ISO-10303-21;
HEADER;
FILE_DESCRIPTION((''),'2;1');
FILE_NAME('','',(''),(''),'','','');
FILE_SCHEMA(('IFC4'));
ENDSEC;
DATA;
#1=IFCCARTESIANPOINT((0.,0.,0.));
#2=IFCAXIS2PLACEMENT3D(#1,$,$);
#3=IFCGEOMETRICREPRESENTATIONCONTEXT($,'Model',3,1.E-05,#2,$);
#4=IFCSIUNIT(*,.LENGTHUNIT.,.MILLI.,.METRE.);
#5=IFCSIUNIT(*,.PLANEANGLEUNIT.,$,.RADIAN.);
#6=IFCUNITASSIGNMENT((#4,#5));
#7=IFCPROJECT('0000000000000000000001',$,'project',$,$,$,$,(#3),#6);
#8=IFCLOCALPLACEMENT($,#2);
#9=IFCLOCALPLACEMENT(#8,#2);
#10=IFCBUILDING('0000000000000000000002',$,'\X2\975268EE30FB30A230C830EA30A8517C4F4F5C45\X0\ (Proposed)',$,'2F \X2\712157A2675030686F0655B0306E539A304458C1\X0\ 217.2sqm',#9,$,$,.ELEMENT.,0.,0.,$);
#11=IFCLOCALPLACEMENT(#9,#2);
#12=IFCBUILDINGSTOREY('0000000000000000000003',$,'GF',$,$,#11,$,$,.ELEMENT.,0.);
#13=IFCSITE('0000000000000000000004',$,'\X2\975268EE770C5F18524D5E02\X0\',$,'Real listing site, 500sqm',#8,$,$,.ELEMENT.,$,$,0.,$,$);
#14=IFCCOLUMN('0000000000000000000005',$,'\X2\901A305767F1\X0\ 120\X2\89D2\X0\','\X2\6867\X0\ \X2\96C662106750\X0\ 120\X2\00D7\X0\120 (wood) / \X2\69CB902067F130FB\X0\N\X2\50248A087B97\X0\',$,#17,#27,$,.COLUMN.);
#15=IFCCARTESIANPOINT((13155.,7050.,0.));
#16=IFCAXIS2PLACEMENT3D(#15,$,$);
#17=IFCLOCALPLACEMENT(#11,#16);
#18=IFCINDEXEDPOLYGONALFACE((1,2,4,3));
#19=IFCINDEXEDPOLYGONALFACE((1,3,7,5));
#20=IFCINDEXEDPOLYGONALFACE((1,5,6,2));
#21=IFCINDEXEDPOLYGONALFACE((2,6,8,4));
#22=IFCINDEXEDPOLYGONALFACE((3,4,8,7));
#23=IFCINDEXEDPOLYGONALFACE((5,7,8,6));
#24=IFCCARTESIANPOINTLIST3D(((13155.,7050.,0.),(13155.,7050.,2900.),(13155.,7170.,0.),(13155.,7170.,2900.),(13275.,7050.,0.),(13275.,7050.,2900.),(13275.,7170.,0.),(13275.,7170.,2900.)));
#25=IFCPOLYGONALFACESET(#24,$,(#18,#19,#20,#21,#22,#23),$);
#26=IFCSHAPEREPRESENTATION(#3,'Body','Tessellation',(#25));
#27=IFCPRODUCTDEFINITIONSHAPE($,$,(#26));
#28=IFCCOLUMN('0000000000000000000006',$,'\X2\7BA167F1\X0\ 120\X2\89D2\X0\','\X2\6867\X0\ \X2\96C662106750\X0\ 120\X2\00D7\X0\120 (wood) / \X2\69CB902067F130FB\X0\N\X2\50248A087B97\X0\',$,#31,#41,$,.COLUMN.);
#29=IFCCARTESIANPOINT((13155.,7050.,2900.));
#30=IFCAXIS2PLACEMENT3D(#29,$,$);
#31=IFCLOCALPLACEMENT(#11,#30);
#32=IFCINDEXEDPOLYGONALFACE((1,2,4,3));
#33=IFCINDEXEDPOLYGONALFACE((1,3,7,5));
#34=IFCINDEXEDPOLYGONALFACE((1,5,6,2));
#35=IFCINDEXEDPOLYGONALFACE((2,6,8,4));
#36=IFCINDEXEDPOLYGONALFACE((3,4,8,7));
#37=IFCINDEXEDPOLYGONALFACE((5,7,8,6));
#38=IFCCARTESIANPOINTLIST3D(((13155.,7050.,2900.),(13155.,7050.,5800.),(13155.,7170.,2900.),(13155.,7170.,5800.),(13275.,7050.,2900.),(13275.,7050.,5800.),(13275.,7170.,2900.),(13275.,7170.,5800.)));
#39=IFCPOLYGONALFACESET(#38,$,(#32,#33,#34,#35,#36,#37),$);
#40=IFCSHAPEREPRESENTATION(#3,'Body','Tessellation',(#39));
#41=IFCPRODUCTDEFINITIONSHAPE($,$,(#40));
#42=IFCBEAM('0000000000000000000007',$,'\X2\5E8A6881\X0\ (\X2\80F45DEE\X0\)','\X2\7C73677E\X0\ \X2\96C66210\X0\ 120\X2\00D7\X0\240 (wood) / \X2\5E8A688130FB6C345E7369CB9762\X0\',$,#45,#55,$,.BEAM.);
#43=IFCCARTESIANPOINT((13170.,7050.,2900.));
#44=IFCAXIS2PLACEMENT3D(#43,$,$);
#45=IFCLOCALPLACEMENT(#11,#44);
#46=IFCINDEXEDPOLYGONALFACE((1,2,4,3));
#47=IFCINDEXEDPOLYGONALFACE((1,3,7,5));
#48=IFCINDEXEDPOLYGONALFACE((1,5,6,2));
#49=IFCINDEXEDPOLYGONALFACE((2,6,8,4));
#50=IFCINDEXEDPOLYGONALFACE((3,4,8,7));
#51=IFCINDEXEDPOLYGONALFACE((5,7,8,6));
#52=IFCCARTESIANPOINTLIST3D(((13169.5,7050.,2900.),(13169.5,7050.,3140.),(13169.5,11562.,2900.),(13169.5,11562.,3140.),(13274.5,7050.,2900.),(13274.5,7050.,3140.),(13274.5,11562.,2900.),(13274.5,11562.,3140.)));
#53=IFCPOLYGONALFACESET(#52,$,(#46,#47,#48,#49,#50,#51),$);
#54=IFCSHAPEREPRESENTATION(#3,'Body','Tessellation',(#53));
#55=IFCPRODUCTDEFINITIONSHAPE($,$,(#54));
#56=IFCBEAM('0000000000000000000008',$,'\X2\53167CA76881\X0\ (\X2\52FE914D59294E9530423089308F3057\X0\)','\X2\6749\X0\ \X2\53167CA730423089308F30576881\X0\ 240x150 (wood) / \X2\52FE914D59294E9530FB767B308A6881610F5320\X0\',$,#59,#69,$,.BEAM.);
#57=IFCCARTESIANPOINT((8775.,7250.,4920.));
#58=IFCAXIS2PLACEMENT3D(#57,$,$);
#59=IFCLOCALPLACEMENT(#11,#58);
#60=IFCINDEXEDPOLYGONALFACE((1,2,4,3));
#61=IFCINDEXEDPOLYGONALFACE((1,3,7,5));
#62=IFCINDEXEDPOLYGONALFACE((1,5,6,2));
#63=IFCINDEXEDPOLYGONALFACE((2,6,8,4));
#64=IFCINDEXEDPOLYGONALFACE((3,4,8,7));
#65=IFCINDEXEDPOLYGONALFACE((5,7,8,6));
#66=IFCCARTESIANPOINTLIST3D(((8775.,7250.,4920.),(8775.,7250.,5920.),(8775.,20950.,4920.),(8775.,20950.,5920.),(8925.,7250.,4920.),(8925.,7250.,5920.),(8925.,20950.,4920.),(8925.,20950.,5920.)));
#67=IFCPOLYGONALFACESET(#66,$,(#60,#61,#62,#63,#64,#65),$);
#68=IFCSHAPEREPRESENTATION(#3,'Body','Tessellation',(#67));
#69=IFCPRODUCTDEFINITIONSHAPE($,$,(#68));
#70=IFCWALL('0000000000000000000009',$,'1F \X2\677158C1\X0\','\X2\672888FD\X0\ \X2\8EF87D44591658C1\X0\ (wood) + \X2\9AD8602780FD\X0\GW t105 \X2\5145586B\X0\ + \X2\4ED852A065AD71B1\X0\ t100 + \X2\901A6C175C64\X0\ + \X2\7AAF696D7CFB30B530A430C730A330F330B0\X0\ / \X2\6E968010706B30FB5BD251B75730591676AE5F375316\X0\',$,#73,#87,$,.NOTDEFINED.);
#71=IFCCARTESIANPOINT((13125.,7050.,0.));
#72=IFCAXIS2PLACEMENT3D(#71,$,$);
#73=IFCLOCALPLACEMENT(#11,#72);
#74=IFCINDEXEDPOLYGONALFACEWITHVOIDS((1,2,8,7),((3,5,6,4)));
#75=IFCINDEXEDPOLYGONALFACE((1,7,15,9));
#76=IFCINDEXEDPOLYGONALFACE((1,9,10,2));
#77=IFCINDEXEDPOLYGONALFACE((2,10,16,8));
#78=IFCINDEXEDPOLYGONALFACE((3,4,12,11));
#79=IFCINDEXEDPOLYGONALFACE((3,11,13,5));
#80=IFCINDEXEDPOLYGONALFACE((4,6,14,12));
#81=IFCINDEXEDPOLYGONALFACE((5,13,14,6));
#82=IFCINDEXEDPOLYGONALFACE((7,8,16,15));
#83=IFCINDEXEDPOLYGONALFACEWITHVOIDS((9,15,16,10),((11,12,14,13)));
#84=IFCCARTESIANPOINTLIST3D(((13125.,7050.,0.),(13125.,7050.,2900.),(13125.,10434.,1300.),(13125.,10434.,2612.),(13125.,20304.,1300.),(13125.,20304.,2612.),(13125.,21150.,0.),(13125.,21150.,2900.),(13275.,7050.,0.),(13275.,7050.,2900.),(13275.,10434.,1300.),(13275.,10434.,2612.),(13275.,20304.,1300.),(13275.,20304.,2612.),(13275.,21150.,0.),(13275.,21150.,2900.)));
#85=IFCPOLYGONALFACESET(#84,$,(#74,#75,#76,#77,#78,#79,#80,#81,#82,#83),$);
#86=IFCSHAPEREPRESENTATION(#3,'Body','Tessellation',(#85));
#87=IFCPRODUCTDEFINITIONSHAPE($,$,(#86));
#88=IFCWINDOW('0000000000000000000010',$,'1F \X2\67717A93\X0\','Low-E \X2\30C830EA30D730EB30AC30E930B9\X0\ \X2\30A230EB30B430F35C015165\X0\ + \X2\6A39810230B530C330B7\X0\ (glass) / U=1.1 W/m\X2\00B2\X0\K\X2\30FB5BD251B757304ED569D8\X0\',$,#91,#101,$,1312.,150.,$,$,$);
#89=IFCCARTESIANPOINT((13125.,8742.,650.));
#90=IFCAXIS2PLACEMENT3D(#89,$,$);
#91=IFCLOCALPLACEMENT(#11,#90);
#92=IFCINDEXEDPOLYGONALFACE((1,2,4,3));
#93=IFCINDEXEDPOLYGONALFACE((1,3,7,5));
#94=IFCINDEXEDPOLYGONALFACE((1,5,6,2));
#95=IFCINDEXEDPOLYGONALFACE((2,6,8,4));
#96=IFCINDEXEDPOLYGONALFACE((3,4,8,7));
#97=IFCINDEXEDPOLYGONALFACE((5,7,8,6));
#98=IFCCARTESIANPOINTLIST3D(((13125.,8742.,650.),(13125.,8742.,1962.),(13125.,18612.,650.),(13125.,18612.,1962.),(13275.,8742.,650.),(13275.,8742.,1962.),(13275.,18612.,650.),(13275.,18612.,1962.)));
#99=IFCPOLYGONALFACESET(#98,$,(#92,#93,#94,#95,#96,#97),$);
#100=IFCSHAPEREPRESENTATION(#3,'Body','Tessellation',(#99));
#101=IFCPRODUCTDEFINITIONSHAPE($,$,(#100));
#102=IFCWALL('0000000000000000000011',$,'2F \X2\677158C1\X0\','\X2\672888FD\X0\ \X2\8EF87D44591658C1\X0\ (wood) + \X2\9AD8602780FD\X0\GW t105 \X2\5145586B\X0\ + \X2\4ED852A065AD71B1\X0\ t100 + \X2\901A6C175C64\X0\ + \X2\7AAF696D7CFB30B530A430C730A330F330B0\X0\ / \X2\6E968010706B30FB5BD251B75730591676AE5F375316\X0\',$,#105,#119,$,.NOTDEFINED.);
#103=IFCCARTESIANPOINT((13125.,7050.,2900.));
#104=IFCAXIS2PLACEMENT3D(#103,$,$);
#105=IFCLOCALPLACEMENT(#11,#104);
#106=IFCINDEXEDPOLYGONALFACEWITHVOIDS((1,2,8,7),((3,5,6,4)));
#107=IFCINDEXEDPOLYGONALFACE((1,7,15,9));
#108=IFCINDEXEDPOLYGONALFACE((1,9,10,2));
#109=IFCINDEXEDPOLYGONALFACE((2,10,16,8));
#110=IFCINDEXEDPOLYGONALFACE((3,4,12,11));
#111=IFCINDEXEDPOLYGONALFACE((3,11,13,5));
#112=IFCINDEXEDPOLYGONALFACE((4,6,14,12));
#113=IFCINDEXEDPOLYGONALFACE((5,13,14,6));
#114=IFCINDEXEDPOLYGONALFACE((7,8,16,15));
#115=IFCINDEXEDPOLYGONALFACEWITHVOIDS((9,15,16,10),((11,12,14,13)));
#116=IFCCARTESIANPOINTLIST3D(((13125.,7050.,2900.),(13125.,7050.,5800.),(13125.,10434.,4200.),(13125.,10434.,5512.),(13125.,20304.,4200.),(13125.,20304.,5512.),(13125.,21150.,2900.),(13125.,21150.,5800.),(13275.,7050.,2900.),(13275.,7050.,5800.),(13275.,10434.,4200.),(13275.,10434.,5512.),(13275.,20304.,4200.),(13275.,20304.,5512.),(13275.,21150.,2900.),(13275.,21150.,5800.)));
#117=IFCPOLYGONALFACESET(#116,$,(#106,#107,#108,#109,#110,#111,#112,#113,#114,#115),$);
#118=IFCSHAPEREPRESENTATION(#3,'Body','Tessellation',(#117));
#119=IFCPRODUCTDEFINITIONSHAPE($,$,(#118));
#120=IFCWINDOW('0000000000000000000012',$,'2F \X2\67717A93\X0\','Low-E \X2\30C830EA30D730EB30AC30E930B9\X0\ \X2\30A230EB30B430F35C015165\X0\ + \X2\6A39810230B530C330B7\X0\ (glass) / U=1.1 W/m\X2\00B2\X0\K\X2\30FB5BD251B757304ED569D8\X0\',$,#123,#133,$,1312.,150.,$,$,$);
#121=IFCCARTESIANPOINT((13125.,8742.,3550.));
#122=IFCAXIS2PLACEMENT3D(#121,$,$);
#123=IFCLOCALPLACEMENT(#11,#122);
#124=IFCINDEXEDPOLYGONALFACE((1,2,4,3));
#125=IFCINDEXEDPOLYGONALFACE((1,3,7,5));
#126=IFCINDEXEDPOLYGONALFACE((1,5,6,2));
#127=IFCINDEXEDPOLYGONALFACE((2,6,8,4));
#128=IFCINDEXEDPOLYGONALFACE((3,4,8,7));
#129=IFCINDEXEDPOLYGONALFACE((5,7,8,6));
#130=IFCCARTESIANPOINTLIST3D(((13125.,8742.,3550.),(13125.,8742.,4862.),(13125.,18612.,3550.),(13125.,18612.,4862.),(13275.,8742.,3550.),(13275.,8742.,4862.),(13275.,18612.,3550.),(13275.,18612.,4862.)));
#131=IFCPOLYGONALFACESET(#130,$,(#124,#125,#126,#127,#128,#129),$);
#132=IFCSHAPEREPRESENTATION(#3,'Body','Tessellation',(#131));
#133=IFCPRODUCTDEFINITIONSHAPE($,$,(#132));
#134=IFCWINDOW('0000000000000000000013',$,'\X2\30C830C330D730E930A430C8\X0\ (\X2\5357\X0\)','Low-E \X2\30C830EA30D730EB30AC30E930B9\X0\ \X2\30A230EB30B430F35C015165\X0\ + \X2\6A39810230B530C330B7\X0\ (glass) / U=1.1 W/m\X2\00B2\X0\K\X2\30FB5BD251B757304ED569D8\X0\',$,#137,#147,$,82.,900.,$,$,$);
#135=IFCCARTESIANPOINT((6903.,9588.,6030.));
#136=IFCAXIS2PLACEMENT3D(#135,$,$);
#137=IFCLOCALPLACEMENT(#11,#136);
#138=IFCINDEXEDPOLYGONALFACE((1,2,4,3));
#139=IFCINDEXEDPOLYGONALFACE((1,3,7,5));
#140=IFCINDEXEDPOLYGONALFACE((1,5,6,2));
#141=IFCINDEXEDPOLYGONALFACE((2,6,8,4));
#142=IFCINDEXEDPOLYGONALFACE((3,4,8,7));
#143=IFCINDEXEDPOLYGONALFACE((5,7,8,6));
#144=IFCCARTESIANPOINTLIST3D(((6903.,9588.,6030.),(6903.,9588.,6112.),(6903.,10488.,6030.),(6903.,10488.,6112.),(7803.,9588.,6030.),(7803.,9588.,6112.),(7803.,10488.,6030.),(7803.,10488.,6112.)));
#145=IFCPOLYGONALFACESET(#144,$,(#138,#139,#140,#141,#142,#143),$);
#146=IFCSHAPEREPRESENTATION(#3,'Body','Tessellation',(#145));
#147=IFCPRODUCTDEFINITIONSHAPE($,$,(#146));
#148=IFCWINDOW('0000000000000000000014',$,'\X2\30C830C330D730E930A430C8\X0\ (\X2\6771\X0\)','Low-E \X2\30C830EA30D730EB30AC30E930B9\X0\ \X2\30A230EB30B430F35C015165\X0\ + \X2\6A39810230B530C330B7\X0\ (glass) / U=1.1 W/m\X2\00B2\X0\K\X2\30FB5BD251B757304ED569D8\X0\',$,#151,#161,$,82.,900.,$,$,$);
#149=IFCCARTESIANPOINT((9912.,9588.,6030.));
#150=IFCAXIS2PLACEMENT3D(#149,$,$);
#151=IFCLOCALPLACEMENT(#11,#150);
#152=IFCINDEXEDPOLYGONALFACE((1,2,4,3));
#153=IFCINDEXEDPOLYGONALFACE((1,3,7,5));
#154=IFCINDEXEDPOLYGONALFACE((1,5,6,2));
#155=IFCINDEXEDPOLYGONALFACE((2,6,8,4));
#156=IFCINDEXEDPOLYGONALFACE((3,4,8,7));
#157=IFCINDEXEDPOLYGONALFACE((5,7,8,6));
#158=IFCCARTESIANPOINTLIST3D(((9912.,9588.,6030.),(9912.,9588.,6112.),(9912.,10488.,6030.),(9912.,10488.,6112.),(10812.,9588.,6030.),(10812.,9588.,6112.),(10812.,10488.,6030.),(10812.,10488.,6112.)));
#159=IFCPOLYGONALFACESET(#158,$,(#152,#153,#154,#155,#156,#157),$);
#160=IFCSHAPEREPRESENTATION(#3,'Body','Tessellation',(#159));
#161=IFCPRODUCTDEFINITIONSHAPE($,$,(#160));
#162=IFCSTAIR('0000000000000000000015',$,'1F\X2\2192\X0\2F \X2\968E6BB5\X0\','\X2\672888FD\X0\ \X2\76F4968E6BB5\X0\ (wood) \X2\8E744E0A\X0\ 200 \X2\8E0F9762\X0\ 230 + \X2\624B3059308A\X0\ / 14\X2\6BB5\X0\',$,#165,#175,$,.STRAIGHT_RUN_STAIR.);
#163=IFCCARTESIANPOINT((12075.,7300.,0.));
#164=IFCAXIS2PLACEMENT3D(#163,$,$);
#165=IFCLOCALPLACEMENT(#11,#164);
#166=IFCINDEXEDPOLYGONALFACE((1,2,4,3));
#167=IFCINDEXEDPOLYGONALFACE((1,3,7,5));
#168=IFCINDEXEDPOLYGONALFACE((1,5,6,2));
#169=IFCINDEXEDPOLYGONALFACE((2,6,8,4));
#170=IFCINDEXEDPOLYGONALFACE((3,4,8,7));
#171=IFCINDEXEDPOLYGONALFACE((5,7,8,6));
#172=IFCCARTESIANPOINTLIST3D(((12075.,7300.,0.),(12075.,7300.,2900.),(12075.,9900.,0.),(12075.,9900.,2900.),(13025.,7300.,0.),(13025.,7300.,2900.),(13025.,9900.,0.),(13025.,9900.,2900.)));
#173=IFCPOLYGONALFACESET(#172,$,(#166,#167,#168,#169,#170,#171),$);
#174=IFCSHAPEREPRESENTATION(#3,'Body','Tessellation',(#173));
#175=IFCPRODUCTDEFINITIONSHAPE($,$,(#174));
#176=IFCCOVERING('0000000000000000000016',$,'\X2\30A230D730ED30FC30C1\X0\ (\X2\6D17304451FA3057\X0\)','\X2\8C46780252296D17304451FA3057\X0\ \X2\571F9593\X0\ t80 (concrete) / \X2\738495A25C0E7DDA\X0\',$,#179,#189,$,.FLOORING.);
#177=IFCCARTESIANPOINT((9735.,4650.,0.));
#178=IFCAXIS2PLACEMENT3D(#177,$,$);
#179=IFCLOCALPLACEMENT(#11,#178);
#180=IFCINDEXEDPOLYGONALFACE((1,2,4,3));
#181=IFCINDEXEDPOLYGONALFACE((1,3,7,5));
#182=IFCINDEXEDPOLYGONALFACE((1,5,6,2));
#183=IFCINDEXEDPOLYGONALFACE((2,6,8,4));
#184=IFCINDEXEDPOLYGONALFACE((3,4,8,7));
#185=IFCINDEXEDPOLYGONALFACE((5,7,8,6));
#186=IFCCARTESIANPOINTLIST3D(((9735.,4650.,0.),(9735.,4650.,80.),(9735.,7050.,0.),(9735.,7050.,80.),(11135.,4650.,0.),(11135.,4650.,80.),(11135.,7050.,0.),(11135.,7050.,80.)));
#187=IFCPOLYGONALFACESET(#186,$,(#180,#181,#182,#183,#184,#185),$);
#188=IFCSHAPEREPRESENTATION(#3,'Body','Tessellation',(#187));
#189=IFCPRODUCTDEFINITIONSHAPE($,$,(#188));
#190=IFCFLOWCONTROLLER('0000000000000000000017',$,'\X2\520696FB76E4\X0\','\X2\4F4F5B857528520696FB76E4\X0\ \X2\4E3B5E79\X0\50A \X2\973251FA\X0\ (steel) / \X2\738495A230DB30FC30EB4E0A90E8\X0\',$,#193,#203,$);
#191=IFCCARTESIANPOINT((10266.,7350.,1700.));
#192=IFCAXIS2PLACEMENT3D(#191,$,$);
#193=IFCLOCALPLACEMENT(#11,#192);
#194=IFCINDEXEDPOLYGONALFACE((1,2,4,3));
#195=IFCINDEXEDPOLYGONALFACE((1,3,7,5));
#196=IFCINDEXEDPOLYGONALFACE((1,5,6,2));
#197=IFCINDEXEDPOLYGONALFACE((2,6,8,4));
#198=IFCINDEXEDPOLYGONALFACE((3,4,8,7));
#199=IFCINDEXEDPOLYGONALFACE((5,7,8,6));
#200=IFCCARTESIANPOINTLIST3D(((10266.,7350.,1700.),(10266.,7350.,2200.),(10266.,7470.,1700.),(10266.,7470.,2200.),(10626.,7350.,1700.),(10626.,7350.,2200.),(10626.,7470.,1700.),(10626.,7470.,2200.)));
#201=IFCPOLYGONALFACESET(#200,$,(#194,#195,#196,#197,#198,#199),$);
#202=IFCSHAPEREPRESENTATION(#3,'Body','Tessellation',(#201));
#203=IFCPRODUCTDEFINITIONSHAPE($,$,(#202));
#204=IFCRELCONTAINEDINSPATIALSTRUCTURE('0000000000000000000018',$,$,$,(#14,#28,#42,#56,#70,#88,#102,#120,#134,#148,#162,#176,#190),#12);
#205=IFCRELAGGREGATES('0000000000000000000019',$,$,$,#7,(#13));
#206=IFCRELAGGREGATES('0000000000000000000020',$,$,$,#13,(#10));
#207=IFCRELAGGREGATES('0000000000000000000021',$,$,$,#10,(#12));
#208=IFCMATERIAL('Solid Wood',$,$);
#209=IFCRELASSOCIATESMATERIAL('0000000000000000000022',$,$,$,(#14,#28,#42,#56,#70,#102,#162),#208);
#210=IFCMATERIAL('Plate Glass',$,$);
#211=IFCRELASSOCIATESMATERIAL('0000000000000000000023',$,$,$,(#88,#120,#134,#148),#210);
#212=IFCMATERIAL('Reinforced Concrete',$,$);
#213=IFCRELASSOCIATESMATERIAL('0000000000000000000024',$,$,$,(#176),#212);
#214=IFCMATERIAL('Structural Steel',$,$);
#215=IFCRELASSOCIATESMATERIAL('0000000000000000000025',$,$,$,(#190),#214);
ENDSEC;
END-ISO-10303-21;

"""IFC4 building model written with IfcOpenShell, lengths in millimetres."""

from ifc_helpers import new_model, si_unit, frame, frame_2d, origin, place, context, project, spatial, rectangle, extrude, material, element, fill, save


model = new_model("IFC4")

# Units and contexts
model_context = context("Model", 3, precision=1e-05, world=origin())
ifc_project = project(units=[si_unit("LENGTHUNIT", "METRE", prefix="MILLI"), si_unit("PLANEANGLEUNIT", "RADIAN")], contexts=[model_context])

# Site, building, storey
site_placement = place(None, origin())
site = spatial("IfcSite", under=ifc_project, at=site_placement, Name="青森県弘前市", ObjectType="Real listing site, 500sqm", CompositionType="ELEMENT", RefElevation=0.0)
building_placement = place(site_placement, origin())
building = spatial("IfcBuilding", under=site, at=building_placement, Name="青森・アトリエ兼住居 (Proposed)", ObjectType="2F 無垢材と漆喰の厚い壁 217.2sqm", CompositionType="ELEMENT", ElevationOfRefHeight=0.0, ElevationOfTerrain=0.0)
storey_placement = place(building_placement, origin())
storey = spatial("IfcBuildingStorey", under=building, at=storey_placement, Name="GF", CompositionType="ELEMENT", Elevation=0.0)

# Columns
ifc_material_1 = material(Name="Solid Wood")
column_1_placement = place(storey_placement, frame((13155.0, 7050.0, 0.0)))
element("IfcColumn", 1, at=column_1_placement, inside=storey, material=ifc_material_1, Name="通し柱 120角", Description="桧 集成材 120×120 (wood) / 構造柱・N値計算", PredefinedType="COLUMN", context=model_context, shape_type="SweptSolid", body=[
    extrude(rectangle(XDim=120.0, YDim=120.0, at=frame_2d((60.0, 60.0))), frame((13155.0, 7050.0, 0.0)), (0.0, 0.0, 1.0), 2900.0),
])
column_2_placement = place(storey_placement, frame((13155.0, 7050.0, 2900.0)))
element("IfcColumn", 2, at=column_2_placement, inside=storey, material=ifc_material_1, Name="管柱 120角", Description="桧 集成材 120×120 (wood) / 構造柱・N値計算", PredefinedType="COLUMN", context=model_context, shape_type="SweptSolid", body=[
    extrude(rectangle(XDim=120.0, YDim=120.0, at=frame_2d((60.0, 60.0))), frame((13155.0, 7050.0, 2900.0)), (0.0, 0.0, 1.0), 2900.0),
])

# Beams
beam_1_placement = place(storey_placement, frame((13170.0, 7050.0, 2900.0)))
element("IfcBeam", 3, at=beam_1_placement, inside=storey, material=ifc_material_1, Name="床梁 (胴差)", Description="米松 集成 120×240 (wood) / 床梁・水平構面", PredefinedType="BEAM", context=model_context, shape_type="SweptSolid", body=[
    extrude(rectangle(XDim=105.0, YDim=4512.0, at=frame_2d((52.0, 2256.0))), frame((13170.0, 7050.0, 2900.0)), (0.0, 0.0, 1.0), 240.0),
])
beam_2_placement = place(storey_placement, frame((8775.0, 7250.0, 4920.0)))
element("IfcBeam", 4, at=beam_2_placement, inside=storey, material=ifc_material_1, Name="化粧梁 (勾配天井あらわし)", Description="杉 化粧あらわし梁 240x150 (wood) / 勾配天井・登り梁意匠", PredefinedType="BEAM", context=model_context, shape_type="SweptSolid", body=[
    extrude(rectangle(XDim=150.0, YDim=13700.0, at=frame_2d((75.0, 6850.0))), frame((8775.0, 7250.0, 4920.0)), (0.0, 0.0, 1.0), 1000.0),
])

# Wall, opening, window
wall_1_placement = place(storey_placement, frame((13125.0, 7050.0, 0.0)))
wall_1 = element("IfcWall", 5, at=wall_1_placement, inside=storey, material=ifc_material_1, Name="1F 東壁", Description="木製 軸組外壁 (wood) + 高性能GW t105 充填 + 付加断熱 t100 + 通気層 + 窯業系サイディング / 準耐火・寒冷地外皮強化", PredefinedType="NOTDEFINED", context=model_context, shape_type="SweptSolid", body=[
    extrude(rectangle(XDim=150.0, YDim=14100.0, at=frame_2d((75.0, 7050.0))), frame((13125.0, 7050.0, 0.0)), (0.0, 0.0, 1.0), 2900.0),
])
opening_1_placement = place(storey_placement, frame((13125.0, 8742.0, 650.0)))
opening_1 = element("IfcOpeningElement", 6, at=opening_1_placement, cuts=wall_1, PredefinedType="NOTDEFINED", context=model_context, shape_type="SweptSolid", body=[
    extrude(rectangle(XDim=150.0, YDim=9870.0, at=frame_2d((75.0, 4935.0))), frame((13125.0, 8742.0, 650.0)), (0.0, 0.0, 1.0), 1312.0),
])
ifc_material_2 = material(Name="Plate Glass")
window_1_placement = place(storey_placement, frame((13125.0, 8742.0, 650.0)))
window_1 = element("IfcWindow", 7, at=window_1_placement, inside=storey, material=ifc_material_2, Name="1F 東窓", Description="Low-E トリプルガラス アルゴン封入 + 樹脂サッシ (glass) / U=1.1 W/m²K・寒冷地仕様", OverallHeight=1312.0, OverallWidth=150.0, context=model_context, shape_type="SweptSolid", body=[
    extrude(rectangle(XDim=150.0, YDim=9870.0, at=frame_2d((75.0, 4935.0))), frame((13125.0, 8742.0, 650.0)), (0.0, 0.0, 1.0), 1312.0),
])
fill(opening_1, window_1)

# Wall, opening, window
wall_2_placement = place(storey_placement, frame((13125.0, 7050.0, 2900.0)))
wall_2 = element("IfcWall", 8, at=wall_2_placement, inside=storey, material=ifc_material_1, Name="2F 東壁", Description="木製 軸組外壁 (wood) + 高性能GW t105 充填 + 付加断熱 t100 + 通気層 + 窯業系サイディング / 準耐火・寒冷地外皮強化", PredefinedType="NOTDEFINED", context=model_context, shape_type="SweptSolid", body=[
    extrude(rectangle(XDim=150.0, YDim=14100.0, at=frame_2d((75.0, 7050.0))), frame((13125.0, 7050.0, 2900.0)), (0.0, 0.0, 1.0), 2900.0),
])
opening_2_placement = place(storey_placement, frame((13125.0, 8742.0, 3550.0)))
opening_2 = element("IfcOpeningElement", 9, at=opening_2_placement, cuts=wall_2, PredefinedType="NOTDEFINED", context=model_context, shape_type="SweptSolid", body=[
    extrude(rectangle(XDim=150.0, YDim=9870.0, at=frame_2d((75.0, 4935.0))), frame((13125.0, 8742.0, 3550.0)), (0.0, 0.0, 1.0), 1312.0),
])
window_2_placement = place(storey_placement, frame((13125.0, 8742.0, 3550.0)))
window_2 = element("IfcWindow", 10, at=window_2_placement, inside=storey, material=ifc_material_2, Name="2F 東窓", Description="Low-E トリプルガラス アルゴン封入 + 樹脂サッシ (glass) / U=1.1 W/m²K・寒冷地仕様", OverallHeight=1312.0, OverallWidth=150.0, context=model_context, shape_type="SweptSolid", body=[
    extrude(rectangle(XDim=150.0, YDim=9870.0, at=frame_2d((75.0, 4935.0))), frame((13125.0, 8742.0, 3550.0)), (0.0, 0.0, 1.0), 1312.0),
])
fill(opening_2, window_2)

# Windows
window_3_placement = place(storey_placement, frame((6903.0, 9588.0, 6030.0)))
element("IfcWindow", 11, at=window_3_placement, inside=storey, material=ifc_material_2, Name="トップライト (南)", Description="Low-E トリプルガラス アルゴン封入 + 樹脂サッシ (glass) / U=1.1 W/m²K・寒冷地仕様", OverallHeight=82.0, OverallWidth=900.0, context=model_context, shape_type="SweptSolid", body=[
    extrude(rectangle(XDim=900.0, YDim=900.0, at=frame_2d((450.0, 450.0))), frame((6903.0, 9588.0, 6030.0)), (0.0, 0.0, 1.0), 82.0),
])
window_4_placement = place(storey_placement, frame((9912.0, 9588.0, 6030.0)))
element("IfcWindow", 12, at=window_4_placement, inside=storey, material=ifc_material_2, Name="トップライト (東)", Description="Low-E トリプルガラス アルゴン封入 + 樹脂サッシ (glass) / U=1.1 W/m²K・寒冷地仕様", OverallHeight=82.0, OverallWidth=900.0, context=model_context, shape_type="SweptSolid", body=[
    extrude(rectangle(XDim=900.0, YDim=900.0, at=frame_2d((450.0, 450.0))), frame((9912.0, 9588.0, 6030.0)), (0.0, 0.0, 1.0), 82.0),
])

# Stair
stair_placement = place(storey_placement, frame((12075.0, 7300.0, 0.0)))
element("IfcStair", 13, at=stair_placement, inside=storey, material=ifc_material_1, Name="1F→2F 階段", Description="木製 直階段 (wood) 蹴上 200 踏面 230 + 手すり / 14段", PredefinedType="STRAIGHT_RUN_STAIR", context=model_context, shape_type="SweptSolid", body=[
    extrude(rectangle(XDim=950.0, YDim=2600.0, at=frame_2d((475.0, 1300.0))), frame((12075.0, 7300.0, 0.0)), (0.0, 0.0, 1.0), 2900.0),
])

# Covering
ifc_material_3 = material(Name="Reinforced Concrete")
covering_placement = place(storey_placement, frame((9735.0, 4650.0, 0.0)))
element("IfcCovering", 14, at=covering_placement, inside=storey, material=ifc_material_3, Name="アプローチ (洗い出し)", Description="豆砂利洗い出し 土間 t80 (concrete) / 玄関導線", PredefinedType="FLOORING", context=model_context, shape_type="SweptSolid", body=[
    extrude(rectangle(XDim=1400.0, YDim=2400.0, at=frame_2d((700.0, 1200.0))), frame((9735.0, 4650.0, 0.0)), (0.0, 0.0, 1.0), 80.0),
])

# Flow controller
ifc_material_4 = material(Name="Structural Steel")
flow_controller_placement = place(storey_placement, frame((10266.0, 7350.0, 1700.0)))
element("IfcFlowController", 15, at=flow_controller_placement, inside=storey, material=ifc_material_4, Name="分電盤", Description="住宅用分電盤 主幹50A 露出 (steel) / 玄関ホール上部", context=model_context, shape_type="SweptSolid", body=[
    extrude(rectangle(XDim=360.0, YDim=120.0, at=frame_2d((180.0, 60.0))), frame((10266.0, 7350.0, 1700.0)), (0.0, 0.0, 1.0), 500.0),
])

save(model, "model.ifc")
